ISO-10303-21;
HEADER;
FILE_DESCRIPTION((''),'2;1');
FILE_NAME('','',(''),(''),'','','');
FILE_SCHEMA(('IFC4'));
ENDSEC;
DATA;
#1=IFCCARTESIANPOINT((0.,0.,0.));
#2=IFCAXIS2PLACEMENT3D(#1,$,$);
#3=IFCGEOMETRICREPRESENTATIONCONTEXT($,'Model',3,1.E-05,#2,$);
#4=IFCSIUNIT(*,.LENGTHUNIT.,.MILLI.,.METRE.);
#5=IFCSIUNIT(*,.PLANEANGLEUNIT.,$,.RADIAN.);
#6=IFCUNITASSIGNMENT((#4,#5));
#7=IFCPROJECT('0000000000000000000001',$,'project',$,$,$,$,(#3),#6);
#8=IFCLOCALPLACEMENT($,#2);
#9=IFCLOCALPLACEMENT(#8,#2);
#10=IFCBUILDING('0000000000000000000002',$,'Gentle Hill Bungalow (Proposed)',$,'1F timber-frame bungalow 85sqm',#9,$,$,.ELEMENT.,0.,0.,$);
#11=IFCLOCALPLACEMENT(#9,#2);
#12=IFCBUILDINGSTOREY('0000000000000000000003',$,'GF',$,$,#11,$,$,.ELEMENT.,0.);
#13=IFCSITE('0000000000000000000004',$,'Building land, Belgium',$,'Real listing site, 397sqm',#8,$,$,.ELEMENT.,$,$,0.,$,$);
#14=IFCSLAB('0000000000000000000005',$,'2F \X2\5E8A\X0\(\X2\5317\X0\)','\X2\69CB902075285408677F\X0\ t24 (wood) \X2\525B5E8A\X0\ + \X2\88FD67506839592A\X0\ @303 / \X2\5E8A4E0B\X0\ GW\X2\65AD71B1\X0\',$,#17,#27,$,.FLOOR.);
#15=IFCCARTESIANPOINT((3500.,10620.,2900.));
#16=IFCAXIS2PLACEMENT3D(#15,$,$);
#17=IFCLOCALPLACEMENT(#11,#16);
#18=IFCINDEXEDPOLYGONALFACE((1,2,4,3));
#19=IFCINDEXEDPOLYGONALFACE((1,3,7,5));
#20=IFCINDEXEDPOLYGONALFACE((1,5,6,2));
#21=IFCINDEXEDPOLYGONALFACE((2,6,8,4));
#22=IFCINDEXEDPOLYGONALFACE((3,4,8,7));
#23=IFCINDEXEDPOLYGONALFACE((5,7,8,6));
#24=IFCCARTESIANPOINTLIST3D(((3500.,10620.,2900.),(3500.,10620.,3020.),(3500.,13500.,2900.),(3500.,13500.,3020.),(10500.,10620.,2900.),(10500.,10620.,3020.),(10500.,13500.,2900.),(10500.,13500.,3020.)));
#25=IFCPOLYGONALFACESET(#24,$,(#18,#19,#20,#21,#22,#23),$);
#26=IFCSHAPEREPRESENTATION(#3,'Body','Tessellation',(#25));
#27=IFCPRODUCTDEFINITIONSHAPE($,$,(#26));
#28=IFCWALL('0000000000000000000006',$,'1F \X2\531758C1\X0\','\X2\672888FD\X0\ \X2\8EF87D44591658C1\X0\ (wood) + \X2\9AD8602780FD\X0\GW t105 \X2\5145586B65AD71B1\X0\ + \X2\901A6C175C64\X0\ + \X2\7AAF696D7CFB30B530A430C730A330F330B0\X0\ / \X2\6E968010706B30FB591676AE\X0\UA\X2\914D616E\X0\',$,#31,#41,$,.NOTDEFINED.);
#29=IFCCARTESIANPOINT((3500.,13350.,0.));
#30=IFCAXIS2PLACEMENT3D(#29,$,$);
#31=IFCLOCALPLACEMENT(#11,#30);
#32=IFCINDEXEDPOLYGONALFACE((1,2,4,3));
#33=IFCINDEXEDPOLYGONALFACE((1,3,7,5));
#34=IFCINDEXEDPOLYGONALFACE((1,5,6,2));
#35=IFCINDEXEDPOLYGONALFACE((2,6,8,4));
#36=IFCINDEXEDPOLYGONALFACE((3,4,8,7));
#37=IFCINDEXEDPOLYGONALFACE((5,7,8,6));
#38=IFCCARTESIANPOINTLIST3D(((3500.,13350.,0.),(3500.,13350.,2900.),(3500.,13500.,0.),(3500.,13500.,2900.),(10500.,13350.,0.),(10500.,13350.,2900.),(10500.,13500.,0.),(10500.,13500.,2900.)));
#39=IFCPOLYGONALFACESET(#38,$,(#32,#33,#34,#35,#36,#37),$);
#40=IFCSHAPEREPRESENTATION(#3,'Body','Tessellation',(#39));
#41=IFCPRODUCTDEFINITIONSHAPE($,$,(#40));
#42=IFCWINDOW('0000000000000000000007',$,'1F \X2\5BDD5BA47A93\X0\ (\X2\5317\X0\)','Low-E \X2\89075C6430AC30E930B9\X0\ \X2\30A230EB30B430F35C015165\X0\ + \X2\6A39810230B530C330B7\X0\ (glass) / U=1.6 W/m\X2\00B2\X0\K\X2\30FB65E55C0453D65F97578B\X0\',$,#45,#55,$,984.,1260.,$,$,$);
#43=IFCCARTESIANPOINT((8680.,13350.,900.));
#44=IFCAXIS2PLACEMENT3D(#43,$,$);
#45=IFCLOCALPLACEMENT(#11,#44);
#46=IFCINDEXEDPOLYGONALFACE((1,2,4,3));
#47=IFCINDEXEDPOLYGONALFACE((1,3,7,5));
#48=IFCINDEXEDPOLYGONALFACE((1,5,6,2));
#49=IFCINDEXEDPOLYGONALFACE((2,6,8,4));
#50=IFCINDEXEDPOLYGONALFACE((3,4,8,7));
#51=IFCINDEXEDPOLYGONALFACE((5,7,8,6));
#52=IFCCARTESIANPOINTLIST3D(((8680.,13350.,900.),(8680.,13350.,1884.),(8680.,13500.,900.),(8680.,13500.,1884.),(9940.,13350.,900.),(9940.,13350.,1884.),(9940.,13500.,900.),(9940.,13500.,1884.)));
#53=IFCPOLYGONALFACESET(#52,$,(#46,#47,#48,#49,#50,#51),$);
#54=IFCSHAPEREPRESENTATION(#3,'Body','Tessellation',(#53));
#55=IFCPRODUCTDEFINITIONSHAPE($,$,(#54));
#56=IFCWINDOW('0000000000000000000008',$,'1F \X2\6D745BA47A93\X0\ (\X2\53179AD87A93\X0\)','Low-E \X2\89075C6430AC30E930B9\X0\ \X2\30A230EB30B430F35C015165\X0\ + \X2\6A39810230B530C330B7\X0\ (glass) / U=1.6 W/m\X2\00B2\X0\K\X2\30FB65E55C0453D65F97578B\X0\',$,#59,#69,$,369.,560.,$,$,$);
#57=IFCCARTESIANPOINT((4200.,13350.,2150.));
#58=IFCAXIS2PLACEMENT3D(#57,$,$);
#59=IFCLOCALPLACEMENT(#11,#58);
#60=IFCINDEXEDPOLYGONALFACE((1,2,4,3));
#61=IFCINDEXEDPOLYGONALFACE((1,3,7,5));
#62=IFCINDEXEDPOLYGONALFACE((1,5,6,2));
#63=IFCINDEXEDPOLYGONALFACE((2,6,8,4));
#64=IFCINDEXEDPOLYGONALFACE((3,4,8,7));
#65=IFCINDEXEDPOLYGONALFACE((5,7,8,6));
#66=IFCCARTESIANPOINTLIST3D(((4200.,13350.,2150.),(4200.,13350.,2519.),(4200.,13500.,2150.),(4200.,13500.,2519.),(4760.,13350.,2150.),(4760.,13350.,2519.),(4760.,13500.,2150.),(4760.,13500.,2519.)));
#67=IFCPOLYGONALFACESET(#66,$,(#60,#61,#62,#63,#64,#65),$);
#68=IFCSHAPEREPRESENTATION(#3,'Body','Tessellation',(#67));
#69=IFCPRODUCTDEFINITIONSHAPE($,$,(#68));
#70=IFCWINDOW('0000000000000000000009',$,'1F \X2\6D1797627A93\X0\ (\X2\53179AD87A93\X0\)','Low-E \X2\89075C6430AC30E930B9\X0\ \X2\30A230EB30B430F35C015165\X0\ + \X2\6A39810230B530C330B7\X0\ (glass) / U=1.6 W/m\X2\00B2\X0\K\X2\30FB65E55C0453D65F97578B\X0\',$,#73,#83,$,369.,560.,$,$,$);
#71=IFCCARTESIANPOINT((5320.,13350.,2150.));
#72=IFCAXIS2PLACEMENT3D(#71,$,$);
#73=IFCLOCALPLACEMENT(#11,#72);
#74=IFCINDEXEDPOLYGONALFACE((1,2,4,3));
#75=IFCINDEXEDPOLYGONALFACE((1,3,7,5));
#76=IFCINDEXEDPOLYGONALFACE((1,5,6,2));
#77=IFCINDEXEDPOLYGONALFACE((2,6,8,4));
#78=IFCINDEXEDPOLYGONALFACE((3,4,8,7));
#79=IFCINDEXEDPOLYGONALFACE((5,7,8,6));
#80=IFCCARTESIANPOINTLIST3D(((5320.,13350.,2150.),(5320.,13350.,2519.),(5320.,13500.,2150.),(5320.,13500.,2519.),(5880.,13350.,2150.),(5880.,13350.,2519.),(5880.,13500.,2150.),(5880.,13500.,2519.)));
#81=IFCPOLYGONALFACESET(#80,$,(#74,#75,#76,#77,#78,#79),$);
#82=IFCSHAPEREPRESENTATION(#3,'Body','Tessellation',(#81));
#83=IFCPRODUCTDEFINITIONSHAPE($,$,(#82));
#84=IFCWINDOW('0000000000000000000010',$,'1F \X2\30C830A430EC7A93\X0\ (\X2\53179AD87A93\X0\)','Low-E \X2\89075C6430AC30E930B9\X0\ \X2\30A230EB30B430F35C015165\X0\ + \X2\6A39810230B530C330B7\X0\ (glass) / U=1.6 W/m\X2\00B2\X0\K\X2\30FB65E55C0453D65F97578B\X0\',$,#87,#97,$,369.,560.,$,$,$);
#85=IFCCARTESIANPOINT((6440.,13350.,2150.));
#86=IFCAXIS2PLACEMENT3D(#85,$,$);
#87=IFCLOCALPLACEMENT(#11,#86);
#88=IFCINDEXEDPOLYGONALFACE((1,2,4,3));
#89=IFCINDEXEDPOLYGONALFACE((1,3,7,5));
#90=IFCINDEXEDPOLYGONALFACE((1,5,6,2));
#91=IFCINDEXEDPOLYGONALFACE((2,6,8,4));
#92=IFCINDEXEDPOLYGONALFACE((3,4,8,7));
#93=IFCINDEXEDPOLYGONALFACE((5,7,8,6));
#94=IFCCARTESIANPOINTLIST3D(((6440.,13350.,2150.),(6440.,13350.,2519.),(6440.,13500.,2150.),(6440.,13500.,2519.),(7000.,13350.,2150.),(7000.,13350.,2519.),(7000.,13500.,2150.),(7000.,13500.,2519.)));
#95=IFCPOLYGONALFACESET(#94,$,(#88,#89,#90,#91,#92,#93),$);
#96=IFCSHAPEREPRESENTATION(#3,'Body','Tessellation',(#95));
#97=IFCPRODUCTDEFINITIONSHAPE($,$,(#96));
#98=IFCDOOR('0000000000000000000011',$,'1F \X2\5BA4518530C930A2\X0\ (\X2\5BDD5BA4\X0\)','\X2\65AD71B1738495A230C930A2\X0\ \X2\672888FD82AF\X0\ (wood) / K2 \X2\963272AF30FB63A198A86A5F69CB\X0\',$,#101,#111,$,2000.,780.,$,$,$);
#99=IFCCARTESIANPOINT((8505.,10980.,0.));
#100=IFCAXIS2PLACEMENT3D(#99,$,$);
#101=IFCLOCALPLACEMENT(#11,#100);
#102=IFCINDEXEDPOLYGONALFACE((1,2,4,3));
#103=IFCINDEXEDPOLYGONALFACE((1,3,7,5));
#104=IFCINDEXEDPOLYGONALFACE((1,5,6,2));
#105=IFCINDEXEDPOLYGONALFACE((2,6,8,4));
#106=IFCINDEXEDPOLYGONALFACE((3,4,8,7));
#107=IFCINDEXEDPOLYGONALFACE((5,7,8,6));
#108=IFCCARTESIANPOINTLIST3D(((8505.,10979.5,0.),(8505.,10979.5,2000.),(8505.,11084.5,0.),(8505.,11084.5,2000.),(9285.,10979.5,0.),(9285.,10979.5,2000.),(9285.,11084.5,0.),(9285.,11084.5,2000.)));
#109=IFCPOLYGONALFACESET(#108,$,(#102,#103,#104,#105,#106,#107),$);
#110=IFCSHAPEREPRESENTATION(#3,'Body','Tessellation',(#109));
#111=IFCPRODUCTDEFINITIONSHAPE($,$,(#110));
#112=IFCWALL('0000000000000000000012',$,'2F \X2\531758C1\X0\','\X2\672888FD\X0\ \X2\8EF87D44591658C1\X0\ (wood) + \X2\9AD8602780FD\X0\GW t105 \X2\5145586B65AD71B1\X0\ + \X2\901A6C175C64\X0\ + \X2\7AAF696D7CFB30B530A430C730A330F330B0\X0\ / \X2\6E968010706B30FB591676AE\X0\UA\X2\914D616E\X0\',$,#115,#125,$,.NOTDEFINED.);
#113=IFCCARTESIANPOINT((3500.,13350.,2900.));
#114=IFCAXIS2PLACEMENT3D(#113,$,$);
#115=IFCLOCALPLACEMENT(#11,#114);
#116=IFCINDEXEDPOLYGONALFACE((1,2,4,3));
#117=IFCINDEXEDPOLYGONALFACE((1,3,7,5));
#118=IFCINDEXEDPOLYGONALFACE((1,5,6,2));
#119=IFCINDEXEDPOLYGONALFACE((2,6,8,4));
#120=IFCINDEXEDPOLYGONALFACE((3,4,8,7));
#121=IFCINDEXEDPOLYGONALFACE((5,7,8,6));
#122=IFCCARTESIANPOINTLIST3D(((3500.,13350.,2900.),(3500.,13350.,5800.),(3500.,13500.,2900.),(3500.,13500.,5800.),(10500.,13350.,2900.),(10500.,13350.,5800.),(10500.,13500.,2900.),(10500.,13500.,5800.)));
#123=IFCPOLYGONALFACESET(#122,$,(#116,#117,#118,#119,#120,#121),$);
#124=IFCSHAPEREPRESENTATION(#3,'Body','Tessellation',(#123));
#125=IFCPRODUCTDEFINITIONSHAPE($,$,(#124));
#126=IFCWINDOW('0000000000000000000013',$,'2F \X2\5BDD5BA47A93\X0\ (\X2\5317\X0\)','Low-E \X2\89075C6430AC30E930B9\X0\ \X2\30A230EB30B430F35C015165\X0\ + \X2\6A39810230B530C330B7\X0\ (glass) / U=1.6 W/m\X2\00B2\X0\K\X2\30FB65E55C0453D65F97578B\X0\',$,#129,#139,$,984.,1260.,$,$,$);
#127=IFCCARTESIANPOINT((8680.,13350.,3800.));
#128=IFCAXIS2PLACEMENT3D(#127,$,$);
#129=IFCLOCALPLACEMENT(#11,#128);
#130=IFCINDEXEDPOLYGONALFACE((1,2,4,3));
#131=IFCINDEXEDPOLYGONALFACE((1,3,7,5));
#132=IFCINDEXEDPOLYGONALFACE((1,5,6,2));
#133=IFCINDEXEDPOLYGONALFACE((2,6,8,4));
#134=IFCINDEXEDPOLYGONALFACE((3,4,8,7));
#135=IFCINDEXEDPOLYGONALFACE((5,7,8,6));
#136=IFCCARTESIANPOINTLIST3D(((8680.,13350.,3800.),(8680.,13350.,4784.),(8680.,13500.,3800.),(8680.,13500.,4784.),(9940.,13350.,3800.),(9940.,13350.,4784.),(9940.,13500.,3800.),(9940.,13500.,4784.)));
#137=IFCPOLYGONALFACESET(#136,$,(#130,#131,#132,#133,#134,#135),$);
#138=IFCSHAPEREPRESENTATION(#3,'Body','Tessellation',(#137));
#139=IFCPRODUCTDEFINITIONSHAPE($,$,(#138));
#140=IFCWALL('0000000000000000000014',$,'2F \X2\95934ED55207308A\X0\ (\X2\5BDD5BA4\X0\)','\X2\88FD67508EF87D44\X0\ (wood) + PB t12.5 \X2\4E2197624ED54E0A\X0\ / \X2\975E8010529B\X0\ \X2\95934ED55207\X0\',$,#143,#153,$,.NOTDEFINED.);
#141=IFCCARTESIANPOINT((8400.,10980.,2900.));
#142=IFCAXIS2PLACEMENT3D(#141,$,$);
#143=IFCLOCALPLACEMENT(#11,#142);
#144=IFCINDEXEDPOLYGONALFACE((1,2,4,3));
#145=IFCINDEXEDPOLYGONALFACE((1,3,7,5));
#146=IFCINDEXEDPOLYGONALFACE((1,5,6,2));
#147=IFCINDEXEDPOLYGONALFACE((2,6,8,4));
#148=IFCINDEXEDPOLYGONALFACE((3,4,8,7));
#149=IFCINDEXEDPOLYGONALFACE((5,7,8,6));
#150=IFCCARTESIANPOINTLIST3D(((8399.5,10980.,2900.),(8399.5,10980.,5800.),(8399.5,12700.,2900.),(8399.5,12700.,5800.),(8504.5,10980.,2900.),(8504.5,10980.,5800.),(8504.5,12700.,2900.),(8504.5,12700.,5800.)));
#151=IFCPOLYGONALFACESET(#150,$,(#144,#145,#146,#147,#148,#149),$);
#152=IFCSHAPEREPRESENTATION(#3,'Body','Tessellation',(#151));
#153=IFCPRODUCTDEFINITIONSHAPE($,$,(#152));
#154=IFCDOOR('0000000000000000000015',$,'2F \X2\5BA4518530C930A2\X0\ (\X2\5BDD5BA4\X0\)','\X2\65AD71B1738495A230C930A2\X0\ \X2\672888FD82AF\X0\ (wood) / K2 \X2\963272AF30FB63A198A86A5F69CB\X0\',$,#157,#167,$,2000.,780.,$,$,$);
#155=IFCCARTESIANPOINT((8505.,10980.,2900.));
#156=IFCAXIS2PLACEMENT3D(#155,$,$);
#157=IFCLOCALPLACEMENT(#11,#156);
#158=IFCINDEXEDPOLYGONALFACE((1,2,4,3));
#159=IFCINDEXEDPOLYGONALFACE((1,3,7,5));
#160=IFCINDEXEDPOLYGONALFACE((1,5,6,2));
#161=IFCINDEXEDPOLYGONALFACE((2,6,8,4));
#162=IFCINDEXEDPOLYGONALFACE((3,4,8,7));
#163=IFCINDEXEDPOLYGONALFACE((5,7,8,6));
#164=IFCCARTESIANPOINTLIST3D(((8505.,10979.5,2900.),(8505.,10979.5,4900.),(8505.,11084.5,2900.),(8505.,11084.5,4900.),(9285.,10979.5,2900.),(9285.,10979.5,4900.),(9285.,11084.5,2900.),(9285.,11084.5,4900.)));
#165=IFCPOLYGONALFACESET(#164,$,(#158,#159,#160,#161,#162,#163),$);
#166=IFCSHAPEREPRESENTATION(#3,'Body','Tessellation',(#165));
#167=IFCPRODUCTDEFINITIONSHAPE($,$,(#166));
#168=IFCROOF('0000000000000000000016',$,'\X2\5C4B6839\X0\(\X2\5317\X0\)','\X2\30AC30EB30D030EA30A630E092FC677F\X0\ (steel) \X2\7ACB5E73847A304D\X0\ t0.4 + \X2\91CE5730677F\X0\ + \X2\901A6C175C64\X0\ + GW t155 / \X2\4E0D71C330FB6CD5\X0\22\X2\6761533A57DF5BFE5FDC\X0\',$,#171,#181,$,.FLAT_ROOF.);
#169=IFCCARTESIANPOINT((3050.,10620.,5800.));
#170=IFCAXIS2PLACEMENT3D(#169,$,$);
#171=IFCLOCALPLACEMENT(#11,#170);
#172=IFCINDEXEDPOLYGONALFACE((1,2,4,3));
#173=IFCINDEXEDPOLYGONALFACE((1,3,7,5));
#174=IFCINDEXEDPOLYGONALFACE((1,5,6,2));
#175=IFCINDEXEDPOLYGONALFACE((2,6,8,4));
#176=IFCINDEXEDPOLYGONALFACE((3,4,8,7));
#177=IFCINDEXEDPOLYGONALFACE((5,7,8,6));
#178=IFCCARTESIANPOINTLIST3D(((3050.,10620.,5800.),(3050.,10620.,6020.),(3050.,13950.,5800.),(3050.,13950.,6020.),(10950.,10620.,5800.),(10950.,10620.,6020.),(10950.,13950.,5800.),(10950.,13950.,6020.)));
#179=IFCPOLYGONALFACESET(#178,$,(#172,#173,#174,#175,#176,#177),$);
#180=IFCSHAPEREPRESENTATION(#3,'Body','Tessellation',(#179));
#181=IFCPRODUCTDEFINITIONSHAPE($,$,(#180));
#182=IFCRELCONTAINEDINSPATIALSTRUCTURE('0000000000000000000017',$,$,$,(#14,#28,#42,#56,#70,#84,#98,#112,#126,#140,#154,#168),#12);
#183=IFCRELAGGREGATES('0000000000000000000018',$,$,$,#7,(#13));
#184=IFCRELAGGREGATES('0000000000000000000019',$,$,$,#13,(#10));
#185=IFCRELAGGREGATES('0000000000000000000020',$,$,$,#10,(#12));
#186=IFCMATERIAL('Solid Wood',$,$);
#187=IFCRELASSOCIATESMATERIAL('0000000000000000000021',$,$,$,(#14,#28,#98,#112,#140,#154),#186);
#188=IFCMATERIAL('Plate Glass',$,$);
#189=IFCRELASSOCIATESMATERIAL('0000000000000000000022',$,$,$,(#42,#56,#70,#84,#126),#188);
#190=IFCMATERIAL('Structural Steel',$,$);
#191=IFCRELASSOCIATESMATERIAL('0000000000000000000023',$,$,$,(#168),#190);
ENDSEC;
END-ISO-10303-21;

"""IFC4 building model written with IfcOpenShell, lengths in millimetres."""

from ifc_helpers import new_model, si_unit, frame, frame_2d, origin, place, context, project, spatial, rectangle, extrude, material, element, fill, save


model = new_model("IFC4")

# Units and contexts
model_context = context("Model", 3, precision=1e-05, world=origin())
ifc_project = project(units=[si_unit("LENGTHUNIT", "METRE", prefix="MILLI"), si_unit("PLANEANGLEUNIT", "RADIAN")], contexts=[model_context])

# Site, building, storey
site_placement = place(None, origin())
site = spatial("IfcSite", under=ifc_project, at=site_placement, Name="Building land, Belgium", ObjectType="Real listing site, 397sqm", CompositionType="ELEMENT", RefElevation=0.0)
building_placement = place(site_placement, origin())
building = spatial("IfcBuilding", under=site, at=building_placement, Name="Gentle Hill Bungalow (Proposed)", ObjectType="1F timber-frame bungalow 85sqm", CompositionType="ELEMENT", ElevationOfRefHeight=0.0, ElevationOfTerrain=0.0)
storey_placement = place(building_placement, origin())
storey = spatial("IfcBuildingStorey", under=building, at=storey_placement, Name="GF", CompositionType="ELEMENT", Elevation=0.0)

# Slab
ifc_material_1 = material(Name="Solid Wood")
slab_placement = place(storey_placement, frame((3500.0, 10620.0, 2900.0)))
element("IfcSlab", 1, at=slab_placement, inside=storey, material=ifc_material_1, Name="2F 床(北)", Description="構造用合板 t24 (wood) 剛床 + 製材根太 @303 / 床下 GW断熱", PredefinedType="FLOOR", context=model_context, shape_type="SweptSolid", body=[
    extrude(rectangle(XDim=7000.0, YDim=2880.0, at=frame_2d((3500.0, 1440.0))), frame((3500.0, 10620.0, 2900.0)), (0.0, 0.0, 1.0), 120.0),
])

# Wall, openings, windows
wall_1_placement = place(storey_placement, frame((3500.0, 13350.0, 0.0)))
wall_1 = element("IfcWall", 2, at=wall_1_placement, inside=storey, material=ifc_material_1, Name="1F 北壁", Description="木製 軸組外壁 (wood) + 高性能GW t105 充填断熱 + 通気層 + 窯業系サイディング / 準耐火・外皮UA配慮", PredefinedType="NOTDEFINED", context=model_context, shape_type="SweptSolid", body=[
    extrude(rectangle(XDim=7000.0, YDim=150.0, at=frame_2d((3500.0, 75.0))), frame((3500.0, 13350.0, 0.0)), (0.0, 0.0, 1.0), 2900.0),
])
opening_1_placement = place(storey_placement, frame((8680.0, 13350.0, 900.0)))
opening_1 = element("IfcOpeningElement", 3, at=opening_1_placement, cuts=wall_1, PredefinedType="NOTDEFINED", context=model_context, shape_type="SweptSolid", body=[
    extrude(rectangle(XDim=1260.0, YDim=150.0, at=frame_2d((630.0, 75.0))), frame((8680.0, 13350.0, 900.0)), (0.0, 0.0, 1.0), 984.0),
])
opening_2_placement = place(storey_placement, frame((4200.0, 13350.0, 2150.0)))
opening_2 = element("IfcOpeningElement", 4, at=opening_2_placement, cuts=wall_1, PredefinedType="NOTDEFINED", context=model_context, shape_type="SweptSolid", body=[
    extrude(rectangle(XDim=560.0, YDim=150.0, at=frame_2d((280.0, 75.0))), frame((4200.0, 13350.0, 2150.0)), (0.0, 0.0, 1.0), 369.0),
])
opening_3_placement = place(storey_placement, frame((5320.0, 13350.0, 2150.0)))
opening_3 = element("IfcOpeningElement", 5, at=opening_3_placement, cuts=wall_1, PredefinedType="NOTDEFINED", context=model_context, shape_type="SweptSolid", body=[
    extrude(rectangle(XDim=560.0, YDim=150.0, at=frame_2d((280.0, 75.0))), frame((5320.0, 13350.0, 2150.0)), (0.0, 0.0, 1.0), 369.0),
])
opening_4_placement = place(storey_placement, frame((6440.0, 13350.0, 2150.0)))
opening_4 = element("IfcOpeningElement", 6, at=opening_4_placement, cuts=wall_1, PredefinedType="NOTDEFINED", context=model_context, shape_type="SweptSolid", body=[
    extrude(rectangle(XDim=560.0, YDim=150.0, at=frame_2d((280.0, 75.0))), frame((6440.0, 13350.0, 2150.0)), (0.0, 0.0, 1.0), 369.0),
])
ifc_material_2 = material(Name="Plate Glass")
window_1_placement = place(storey_placement, frame((8680.0, 13350.0, 900.0)))
window_1 = element("IfcWindow", 7, at=window_1_placement, inside=storey, material=ifc_material_2, Name="1F 寝室窓 (北)", Description="Low-E 複層ガラス アルゴン封入 + 樹脂サッシ (glass) / U=1.6 W/m²K・日射取得型", OverallHeight=984.0, OverallWidth=1260.0, context=model_context, shape_type="SweptSolid", body=[
    extrude(rectangle(XDim=1260.0, YDim=150.0, at=frame_2d((630.0, 75.0))), frame((8680.0, 13350.0, 900.0)), (0.0, 0.0, 1.0), 984.0),
])
fill(opening_1, window_1)
window_2_placement = place(storey_placement, frame((4200.0, 13350.0, 2150.0)))
window_2 = element("IfcWindow", 8, at=window_2_placement, inside=storey, material=ifc_material_2, Name="1F 浴室窓 (北高窓)", Description="Low-E 複層ガラス アルゴン封入 + 樹脂サッシ (glass) / U=1.6 W/m²K・日射取得型", OverallHeight=369.0, OverallWidth=560.0, context=model_context, shape_type="SweptSolid", body=[
    extrude(rectangle(XDim=560.0, YDim=150.0, at=frame_2d((280.0, 75.0))), frame((4200.0, 13350.0, 2150.0)), (0.0, 0.0, 1.0), 369.0),
])
fill(opening_2, window_2)
window_3_placement = place(storey_placement, frame((5320.0, 13350.0, 2150.0)))
window_3 = element("IfcWindow", 9, at=window_3_placement, inside=storey, material=ifc_material_2, Name="1F 洗面窓 (北高窓)", Description="Low-E 複層ガラス アルゴン封入 + 樹脂サッシ (glass) / U=1.6 W/m²K・日射取得型", OverallHeight=369.0, OverallWidth=560.0, context=model_context, shape_type="SweptSolid", body=[
    extrude(rectangle(XDim=560.0, YDim=150.0, at=frame_2d((280.0, 75.0))), frame((5320.0, 13350.0, 2150.0)), (0.0, 0.0, 1.0), 369.0),
])
fill(opening_3, window_3)
window_4_placement = place(storey_placement, frame((6440.0, 13350.0, 2150.0)))
window_4 = element("IfcWindow", 10, at=window_4_placement, inside=storey, material=ifc_material_2, Name="1F トイレ窓 (北高窓)", Description="Low-E 複層ガラス アルゴン封入 + 樹脂サッシ (glass) / U=1.6 W/m²K・日射取得型", OverallHeight=369.0, OverallWidth=560.0, context=model_context, shape_type="SweptSolid", body=[
    extrude(rectangle(XDim=560.0, YDim=150.0, at=frame_2d((280.0, 75.0))), frame((6440.0, 13350.0, 2150.0)), (0.0, 0.0, 1.0), 369.0),
])
fill(opening_4, window_4)

# Door
door_1_placement = place(storey_placement, frame((8505.0, 10980.0, 0.0)))
element("IfcDoor", 11, at=door_1_placement, inside=storey, material=ifc_material_1, Name="1F 室内ドア (寝室)", Description="断熱玄関ドア 木製芯 (wood) / K2 防犯・採風機構", OverallHeight=2000.0, OverallWidth=780.0, context=model_context, shape_type="SweptSolid", body=[
    extrude(rectangle(XDim=780.0, YDim=105.0, at=frame_2d((390.0, 52.0))), frame((8505.0, 10980.0, 0.0)), (0.0, 0.0, 1.0), 2000.0),
])

# Wall, opening, window
wall_2_placement = place(storey_placement, frame((3500.0, 13350.0, 2900.0)))
wall_2 = element("IfcWall", 12, at=wall_2_placement, inside=storey, material=ifc_material_1, Name="2F 北壁", Description="木製 軸組外壁 (wood) + 高性能GW t105 充填断熱 + 通気層 + 窯業系サイディング / 準耐火・外皮UA配慮", PredefinedType="NOTDEFINED", context=model_context, shape_type="SweptSolid", body=[
    extrude(rectangle(XDim=7000.0, YDim=150.0, at=frame_2d((3500.0, 75.0))), frame((3500.0, 13350.0, 2900.0)), (0.0, 0.0, 1.0), 2900.0),
])
opening_5_placement = place(storey_placement, frame((8680.0, 13350.0, 3800.0)))
opening_5 = element("IfcOpeningElement", 13, at=opening_5_placement, cuts=wall_2, PredefinedType="NOTDEFINED", context=model_context, shape_type="SweptSolid", body=[
    extrude(rectangle(XDim=1260.0, YDim=150.0, at=frame_2d((630.0, 75.0))), frame((8680.0, 13350.0, 3800.0)), (0.0, 0.0, 1.0), 984.0),
])
window_5_placement = place(storey_placement, frame((8680.0, 13350.0, 3800.0)))
window_5 = element("IfcWindow", 14, at=window_5_placement, inside=storey, material=ifc_material_2, Name="2F 寝室窓 (北)", Description="Low-E 複層ガラス アルゴン封入 + 樹脂サッシ (glass) / U=1.6 W/m²K・日射取得型", OverallHeight=984.0, OverallWidth=1260.0, context=model_context, shape_type="SweptSolid", body=[
    extrude(rectangle(XDim=1260.0, YDim=150.0, at=frame_2d((630.0, 75.0))), frame((8680.0, 13350.0, 3800.0)), (0.0, 0.0, 1.0), 984.0),
])
fill(opening_5, window_5)

# Wall
wall_3_placement = place(storey_placement, frame((8400.0, 10980.0, 2900.0)))
element("IfcWall", 15, at=wall_3_placement, inside=storey, material=ifc_material_1, Name="2F 間仕切り (寝室)", Description="製材軸組 (wood) + PB t12.5 両面仕上 / 非耐力 間仕切", PredefinedType="NOTDEFINED", context=model_context, shape_type="SweptSolid", body=[
    extrude(rectangle(XDim=105.0, YDim=1720.0, at=frame_2d((52.0, 860.0))), frame((8400.0, 10980.0, 2900.0)), (0.0, 0.0, 1.0), 2900.0),
])

# Door
door_2_placement = place(storey_placement, frame((8505.0, 10980.0, 2900.0)))
element("IfcDoor", 16, at=door_2_placement, inside=storey, material=ifc_material_1, Name="2F 室内ドア (寝室)", Description="断熱玄関ドア 木製芯 (wood) / K2 防犯・採風機構", OverallHeight=2000.0, OverallWidth=780.0, context=model_context, shape_type="SweptSolid", body=[
    extrude(rectangle(XDim=780.0, YDim=105.0, at=frame_2d((390.0, 52.0))), frame((8505.0, 10980.0, 2900.0)), (0.0, 0.0, 1.0), 2000.0),
])

# Roof
ifc_material_3 = material(Name="Structural Steel")
roof_placement = place(storey_placement, frame((3050.0, 10620.0, 5800.0)))
element("IfcRoof", 17, at=roof_placement, inside=storey, material=ifc_material_3, Name="屋根(北)", Description="ガルバリウム鋼板 (steel) 立平葺き t0.4 + 野地板 + 通気層 + GW t155 / 不燃・法22条区域対応", PredefinedType="FLAT_ROOF", context=model_context, shape_type="SweptSolid", body=[
    extrude(rectangle(XDim=7900.0, YDim=3330.0, at=frame_2d((3950.0, 1665.0))), frame((3050.0, 10620.0, 5800.0)), (0.0, 0.0, 1.0), 220.0),
])

save(model, "model.ifc")
